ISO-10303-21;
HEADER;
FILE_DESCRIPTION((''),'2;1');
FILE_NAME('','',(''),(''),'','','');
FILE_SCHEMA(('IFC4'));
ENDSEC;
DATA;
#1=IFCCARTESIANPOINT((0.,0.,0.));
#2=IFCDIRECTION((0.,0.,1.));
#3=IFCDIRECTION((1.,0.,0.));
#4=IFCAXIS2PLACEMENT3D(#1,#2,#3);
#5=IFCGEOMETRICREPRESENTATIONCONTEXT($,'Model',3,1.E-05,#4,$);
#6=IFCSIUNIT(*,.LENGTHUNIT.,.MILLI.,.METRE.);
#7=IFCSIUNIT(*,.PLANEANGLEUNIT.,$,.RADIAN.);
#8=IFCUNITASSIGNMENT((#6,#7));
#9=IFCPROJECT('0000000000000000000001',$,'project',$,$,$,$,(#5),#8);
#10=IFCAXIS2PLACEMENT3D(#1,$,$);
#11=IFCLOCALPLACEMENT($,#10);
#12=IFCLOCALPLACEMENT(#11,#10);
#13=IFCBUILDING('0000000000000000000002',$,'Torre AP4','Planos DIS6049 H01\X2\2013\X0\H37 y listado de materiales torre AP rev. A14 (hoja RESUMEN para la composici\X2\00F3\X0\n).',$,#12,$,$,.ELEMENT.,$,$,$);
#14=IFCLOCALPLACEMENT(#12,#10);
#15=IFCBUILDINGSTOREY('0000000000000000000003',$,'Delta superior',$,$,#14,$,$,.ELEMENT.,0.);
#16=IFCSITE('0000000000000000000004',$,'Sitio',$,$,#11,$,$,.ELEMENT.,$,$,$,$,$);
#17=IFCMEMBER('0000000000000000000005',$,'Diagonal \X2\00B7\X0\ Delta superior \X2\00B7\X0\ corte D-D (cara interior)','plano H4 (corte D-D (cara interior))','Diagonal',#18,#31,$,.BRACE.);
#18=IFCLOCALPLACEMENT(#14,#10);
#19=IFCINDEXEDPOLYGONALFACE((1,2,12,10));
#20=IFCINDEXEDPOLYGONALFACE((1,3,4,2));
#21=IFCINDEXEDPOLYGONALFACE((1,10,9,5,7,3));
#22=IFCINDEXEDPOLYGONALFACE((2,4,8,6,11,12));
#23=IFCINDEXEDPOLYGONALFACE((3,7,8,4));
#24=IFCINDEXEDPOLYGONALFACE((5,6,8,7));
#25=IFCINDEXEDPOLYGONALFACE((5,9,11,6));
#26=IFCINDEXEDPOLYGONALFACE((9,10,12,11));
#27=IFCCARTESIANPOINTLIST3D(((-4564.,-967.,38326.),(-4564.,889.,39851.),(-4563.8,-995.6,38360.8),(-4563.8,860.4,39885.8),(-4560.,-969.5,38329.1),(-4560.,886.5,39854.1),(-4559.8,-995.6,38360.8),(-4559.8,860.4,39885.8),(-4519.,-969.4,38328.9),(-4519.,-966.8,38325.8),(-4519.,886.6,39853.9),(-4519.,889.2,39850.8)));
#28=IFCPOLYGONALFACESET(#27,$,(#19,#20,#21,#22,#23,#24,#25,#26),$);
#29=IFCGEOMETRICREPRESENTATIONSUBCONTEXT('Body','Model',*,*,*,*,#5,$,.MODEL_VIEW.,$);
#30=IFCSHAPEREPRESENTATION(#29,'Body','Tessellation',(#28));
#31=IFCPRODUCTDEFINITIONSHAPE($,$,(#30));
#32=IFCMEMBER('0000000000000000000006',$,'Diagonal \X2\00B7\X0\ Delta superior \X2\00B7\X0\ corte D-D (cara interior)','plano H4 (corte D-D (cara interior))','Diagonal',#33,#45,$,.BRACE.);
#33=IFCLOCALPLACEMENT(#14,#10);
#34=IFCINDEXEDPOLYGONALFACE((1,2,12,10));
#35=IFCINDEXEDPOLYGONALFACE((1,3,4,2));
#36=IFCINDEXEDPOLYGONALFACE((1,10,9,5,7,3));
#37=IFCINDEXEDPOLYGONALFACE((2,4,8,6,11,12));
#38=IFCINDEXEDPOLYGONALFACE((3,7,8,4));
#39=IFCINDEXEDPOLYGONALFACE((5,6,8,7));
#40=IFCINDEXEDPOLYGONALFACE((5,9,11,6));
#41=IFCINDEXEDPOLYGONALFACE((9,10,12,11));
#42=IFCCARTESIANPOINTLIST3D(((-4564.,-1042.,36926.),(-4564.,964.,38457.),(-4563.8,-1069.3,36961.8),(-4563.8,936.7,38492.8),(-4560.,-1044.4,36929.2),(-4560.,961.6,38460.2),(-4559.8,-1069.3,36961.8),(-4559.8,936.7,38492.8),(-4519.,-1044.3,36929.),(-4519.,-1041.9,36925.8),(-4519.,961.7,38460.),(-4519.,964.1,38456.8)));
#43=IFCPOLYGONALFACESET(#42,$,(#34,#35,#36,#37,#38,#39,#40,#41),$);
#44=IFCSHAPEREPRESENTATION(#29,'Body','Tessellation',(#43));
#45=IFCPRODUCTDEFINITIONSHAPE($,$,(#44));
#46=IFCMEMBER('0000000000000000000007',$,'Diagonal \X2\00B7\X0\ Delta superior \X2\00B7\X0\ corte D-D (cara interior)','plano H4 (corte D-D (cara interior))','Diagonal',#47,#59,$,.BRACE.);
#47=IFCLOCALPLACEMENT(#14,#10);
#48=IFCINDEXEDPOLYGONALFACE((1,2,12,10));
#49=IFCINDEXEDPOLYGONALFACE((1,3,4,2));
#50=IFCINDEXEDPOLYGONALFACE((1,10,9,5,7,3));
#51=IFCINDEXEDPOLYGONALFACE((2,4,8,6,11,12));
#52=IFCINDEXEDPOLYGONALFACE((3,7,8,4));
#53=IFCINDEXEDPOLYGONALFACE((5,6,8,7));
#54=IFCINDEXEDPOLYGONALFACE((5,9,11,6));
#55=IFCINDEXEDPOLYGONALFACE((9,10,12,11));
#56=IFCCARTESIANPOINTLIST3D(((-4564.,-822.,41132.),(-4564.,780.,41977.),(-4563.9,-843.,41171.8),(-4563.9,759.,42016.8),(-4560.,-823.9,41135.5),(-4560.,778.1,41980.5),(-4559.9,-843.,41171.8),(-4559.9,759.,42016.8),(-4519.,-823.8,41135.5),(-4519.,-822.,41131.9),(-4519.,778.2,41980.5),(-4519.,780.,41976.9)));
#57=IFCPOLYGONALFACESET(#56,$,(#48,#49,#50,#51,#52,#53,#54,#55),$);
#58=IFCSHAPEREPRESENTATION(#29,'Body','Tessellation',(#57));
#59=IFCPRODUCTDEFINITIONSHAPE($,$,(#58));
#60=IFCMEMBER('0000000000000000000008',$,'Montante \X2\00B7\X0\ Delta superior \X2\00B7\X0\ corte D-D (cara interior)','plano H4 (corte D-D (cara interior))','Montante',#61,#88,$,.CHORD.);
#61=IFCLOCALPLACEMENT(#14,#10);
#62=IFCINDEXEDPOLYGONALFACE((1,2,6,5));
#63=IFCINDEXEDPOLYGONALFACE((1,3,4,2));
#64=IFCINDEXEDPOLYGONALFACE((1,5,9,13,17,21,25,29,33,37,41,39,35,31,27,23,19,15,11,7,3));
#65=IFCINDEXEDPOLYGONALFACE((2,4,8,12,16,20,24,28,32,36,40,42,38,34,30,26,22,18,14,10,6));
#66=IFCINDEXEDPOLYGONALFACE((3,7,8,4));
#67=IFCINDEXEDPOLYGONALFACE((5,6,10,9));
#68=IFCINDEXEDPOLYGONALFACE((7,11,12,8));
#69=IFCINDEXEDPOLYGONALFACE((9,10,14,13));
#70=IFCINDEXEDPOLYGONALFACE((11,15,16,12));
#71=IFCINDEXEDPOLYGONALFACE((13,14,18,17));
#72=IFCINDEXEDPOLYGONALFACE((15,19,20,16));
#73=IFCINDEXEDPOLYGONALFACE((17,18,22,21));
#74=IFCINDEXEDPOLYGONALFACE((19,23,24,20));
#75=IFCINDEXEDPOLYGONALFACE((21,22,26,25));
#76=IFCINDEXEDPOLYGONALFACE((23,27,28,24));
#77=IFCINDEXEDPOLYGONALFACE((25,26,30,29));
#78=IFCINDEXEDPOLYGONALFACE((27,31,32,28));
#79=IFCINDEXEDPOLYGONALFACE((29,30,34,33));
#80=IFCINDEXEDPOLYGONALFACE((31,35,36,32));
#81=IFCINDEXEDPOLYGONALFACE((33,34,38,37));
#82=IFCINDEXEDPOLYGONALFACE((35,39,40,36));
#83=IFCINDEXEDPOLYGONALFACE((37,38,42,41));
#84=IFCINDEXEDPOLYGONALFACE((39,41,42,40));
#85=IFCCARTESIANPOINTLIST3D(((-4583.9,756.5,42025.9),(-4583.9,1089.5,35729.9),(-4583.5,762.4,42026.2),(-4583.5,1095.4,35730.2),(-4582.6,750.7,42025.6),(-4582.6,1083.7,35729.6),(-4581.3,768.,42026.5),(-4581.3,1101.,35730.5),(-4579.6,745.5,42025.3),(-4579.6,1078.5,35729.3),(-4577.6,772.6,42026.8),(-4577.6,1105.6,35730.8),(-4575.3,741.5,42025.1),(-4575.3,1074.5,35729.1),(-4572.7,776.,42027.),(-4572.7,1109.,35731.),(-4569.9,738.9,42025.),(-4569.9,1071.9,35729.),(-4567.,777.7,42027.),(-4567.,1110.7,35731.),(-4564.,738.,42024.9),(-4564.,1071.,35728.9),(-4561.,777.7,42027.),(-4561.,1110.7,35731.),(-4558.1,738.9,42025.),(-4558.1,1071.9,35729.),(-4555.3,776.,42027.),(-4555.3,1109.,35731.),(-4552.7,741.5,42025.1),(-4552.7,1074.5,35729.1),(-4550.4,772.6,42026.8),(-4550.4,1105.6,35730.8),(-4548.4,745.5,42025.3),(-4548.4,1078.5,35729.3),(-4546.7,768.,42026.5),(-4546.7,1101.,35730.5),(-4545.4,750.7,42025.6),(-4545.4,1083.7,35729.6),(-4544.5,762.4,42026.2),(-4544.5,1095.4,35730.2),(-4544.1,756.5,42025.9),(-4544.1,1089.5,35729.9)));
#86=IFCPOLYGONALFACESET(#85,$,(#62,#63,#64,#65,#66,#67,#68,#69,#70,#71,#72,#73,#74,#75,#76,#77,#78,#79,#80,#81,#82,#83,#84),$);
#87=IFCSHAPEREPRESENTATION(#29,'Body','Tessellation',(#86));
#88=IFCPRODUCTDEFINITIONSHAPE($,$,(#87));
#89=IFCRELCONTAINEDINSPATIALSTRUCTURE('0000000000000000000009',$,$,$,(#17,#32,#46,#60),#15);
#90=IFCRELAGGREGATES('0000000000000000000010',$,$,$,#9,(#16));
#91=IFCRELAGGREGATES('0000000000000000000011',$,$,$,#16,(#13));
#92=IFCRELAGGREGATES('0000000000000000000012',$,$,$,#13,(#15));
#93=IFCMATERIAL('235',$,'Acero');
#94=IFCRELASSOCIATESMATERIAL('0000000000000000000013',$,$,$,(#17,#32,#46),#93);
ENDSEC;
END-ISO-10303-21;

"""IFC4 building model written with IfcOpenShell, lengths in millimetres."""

from ifc_helpers import new_model, si_unit, frame, frame_2d, origin, origin_with_axes, place, context, subcontext, project, spatial, circle, l_section, extrude, material, element, save


model = new_model("IFC4")

# Units and contexts
model_context = context("Model", 3, precision=1e-05, world=origin_with_axes())
body_context = subcontext(model_context, "Body", "Model", "MODEL_VIEW")
ifc_project = project(units=[si_unit("LENGTHUNIT", "METRE", prefix="MILLI"), si_unit("PLANEANGLEUNIT", "RADIAN")], contexts=[model_context])

# Site, building, storey
site_placement = place(None, origin())
site = spatial("IfcSite", under=ifc_project, at=site_placement, Name="Sitio", CompositionType="ELEMENT")
building_placement = place(site_placement, origin())
building = spatial("IfcBuilding", under=site, at=building_placement, Name="Torre AP4", Description="Planos DIS6049 H01–H37 y listado de materiales torre AP rev. A14 (hoja RESUMEN para la composición).", CompositionType="ELEMENT")
storey_placement = place(building_placement, origin())
storey = spatial("IfcBuildingStorey", under=building, at=storey_placement, Name="Delta superior", CompositionType="ELEMENT", Elevation=0.0)

# Members
ifc_material_1 = material(Name="235", Category="Acero")
member_1_placement = place(storey_placement, frame((-4564.0, 889.0, 39851.0), z_axis=(0.0, -0.772639, -0.634846), x_axis=(0.999985, 0.003444, -0.004191)))
element("IfcMember", 1, at=member_1_placement, inside=storey, material=ifc_material_1, Name="Diagonal · Delta superior · corte D-D (cara interior)", Description="plano H4 (corte D-D (cara interior))", ObjectType="Diagonal", PredefinedType="BRACE", context=body_context, shape_type="SweptSolid", body=[
    extrude(l_section(Depth=45.0, Width=45.0, Thickness=4.0, at=frame_2d((22.5, 22.5))), None, (0.0, 0.0, 1.0), 2402.2),
])
member_2_placement = place(storey_placement, frame((-4564.0, 964.0, 38457.0), z_axis=(0.0, -0.794931, -0.6067), x_axis=(0.999987, 0.003145, -0.004121)))
element("IfcMember", 2, at=member_2_placement, inside=storey, material=ifc_material_1, Name="Diagonal · Delta superior · corte D-D (cara interior)", Description="plano H4 (corte D-D (cara interior))", ObjectType="Diagonal", PredefinedType="BRACE", context=body_context, shape_type="SweptSolid", body=[
    extrude(l_section(Depth=45.0, Width=45.0, Thickness=4.0, at=frame_2d((22.5, 22.5))), None, (0.0, 0.0, 1.0), 2523.5),
])
member_3_placement = place(storey_placement, frame((-4564.0, 780.0, 41977.0), z_axis=(0.0, -0.884499, -0.466543), x_axis=(0.999998, 0.001002, -0.001899)))
element("IfcMember", 3, at=member_3_placement, inside=storey, material=ifc_material_1, Name="Diagonal · Delta superior · corte D-D (cara interior)", Description="plano H4 (corte D-D (cara interior))", ObjectType="Diagonal", PredefinedType="BRACE", context=body_context, shape_type="SweptSolid", body=[
    extrude(l_section(Depth=45.0, Width=45.0, Thickness=4.0, at=frame_2d((22.5, 22.5))), None, (0.0, 0.0, 1.0), 1811.2),
])
member_4_placement = place(storey_placement, frame((-4564.0, 1091.0, 35730.0), z_axis=(0.0, -0.052817, 0.998604), x_axis=(0.0, -0.998604, -0.052817)))
element("IfcMember", 4, at=member_4_placement, inside=storey, Name="Montante · Delta superior · corte D-D (cara interior)", Description="plano H4 (corte D-D (cara interior))", ObjectType="Montante", PredefinedType="CHORD", context=body_context, shape_type="SweptSolid", body=[
    extrude(circle(Radius=20.0), None, (0.0, 0.0, 1.0), 6304.8),
])

save(model, "model.ifc")
